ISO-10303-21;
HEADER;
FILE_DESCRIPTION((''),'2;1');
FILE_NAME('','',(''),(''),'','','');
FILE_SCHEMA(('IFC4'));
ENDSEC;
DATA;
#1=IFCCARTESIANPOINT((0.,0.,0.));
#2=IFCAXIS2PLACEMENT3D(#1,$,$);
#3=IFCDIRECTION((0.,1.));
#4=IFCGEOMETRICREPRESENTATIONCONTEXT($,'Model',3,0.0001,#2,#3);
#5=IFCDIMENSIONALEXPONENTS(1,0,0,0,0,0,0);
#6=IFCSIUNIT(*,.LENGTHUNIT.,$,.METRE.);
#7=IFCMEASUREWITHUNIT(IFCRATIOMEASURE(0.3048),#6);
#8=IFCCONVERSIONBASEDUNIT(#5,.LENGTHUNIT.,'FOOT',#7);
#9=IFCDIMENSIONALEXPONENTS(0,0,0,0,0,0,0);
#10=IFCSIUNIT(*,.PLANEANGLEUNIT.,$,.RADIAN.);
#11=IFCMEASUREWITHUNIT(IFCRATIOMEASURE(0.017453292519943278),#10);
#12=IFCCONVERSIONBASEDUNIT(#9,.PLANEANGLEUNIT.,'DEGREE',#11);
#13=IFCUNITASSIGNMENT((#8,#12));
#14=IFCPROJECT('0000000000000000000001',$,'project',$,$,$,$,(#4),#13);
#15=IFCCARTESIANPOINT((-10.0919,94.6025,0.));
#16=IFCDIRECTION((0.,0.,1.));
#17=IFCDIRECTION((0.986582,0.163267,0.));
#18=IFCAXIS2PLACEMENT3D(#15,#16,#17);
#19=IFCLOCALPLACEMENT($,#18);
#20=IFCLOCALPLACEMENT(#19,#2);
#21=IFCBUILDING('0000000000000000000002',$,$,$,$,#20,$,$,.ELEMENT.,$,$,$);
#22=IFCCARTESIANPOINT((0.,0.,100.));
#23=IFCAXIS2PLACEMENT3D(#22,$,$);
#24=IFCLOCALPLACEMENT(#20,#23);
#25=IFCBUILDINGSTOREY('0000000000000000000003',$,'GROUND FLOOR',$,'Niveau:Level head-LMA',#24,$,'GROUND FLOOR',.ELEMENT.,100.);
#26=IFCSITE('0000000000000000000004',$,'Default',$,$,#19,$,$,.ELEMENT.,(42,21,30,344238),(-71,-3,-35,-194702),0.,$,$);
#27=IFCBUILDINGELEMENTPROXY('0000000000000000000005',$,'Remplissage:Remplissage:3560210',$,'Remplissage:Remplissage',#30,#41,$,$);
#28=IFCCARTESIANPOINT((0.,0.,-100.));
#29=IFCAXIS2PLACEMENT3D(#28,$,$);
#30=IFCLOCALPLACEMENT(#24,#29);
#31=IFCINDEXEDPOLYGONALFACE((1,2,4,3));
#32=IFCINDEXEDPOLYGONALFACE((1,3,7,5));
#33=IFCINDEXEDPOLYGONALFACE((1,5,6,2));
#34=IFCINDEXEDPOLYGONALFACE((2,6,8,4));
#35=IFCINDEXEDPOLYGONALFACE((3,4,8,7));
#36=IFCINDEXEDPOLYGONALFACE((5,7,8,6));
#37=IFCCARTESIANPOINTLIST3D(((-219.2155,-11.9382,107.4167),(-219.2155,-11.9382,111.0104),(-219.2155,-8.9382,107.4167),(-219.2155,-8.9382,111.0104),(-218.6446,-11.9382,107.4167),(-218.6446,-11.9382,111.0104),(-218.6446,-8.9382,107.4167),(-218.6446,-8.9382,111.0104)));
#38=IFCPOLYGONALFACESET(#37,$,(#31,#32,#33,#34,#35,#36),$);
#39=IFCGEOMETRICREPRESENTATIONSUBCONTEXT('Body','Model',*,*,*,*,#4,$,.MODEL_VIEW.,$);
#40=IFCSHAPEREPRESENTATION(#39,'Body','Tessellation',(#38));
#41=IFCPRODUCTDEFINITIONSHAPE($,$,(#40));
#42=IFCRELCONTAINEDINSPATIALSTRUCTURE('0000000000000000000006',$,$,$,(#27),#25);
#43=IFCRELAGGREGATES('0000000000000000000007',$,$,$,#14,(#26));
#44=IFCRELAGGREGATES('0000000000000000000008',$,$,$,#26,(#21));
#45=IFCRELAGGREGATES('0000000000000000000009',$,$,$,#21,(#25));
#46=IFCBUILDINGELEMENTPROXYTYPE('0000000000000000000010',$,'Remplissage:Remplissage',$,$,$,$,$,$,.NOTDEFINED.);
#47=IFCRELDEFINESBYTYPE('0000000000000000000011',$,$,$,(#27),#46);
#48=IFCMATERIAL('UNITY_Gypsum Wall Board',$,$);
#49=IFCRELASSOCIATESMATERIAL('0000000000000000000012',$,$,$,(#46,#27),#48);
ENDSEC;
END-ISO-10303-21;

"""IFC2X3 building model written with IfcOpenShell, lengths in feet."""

from ifc_helpers import new_model, entity, si_unit, converted_unit, direction, frame, origin, origin_2d_with_axis, place, context, subcontext, project, spatial, rectangle, extrude, source, transform, mapped, material, type_object, type_shapes, element, save


model = new_model("IFC2X3")

# Units and contexts
model_context = context("Model", 3, precision=0.0001, world=origin(), true_north=direction((0.0, 1.0)))
body_context = subcontext(model_context, "Body", "Model", "MODEL_VIEW")
ifc_project = project(units=[converted_unit("LENGTHUNIT", "FOOT", entity("IfcRatioMeasure", 0.3048), si_unit("LENGTHUNIT", "METRE"), dimensions=[1, 0, 0, 0, 0, 0, 0]), converted_unit("PLANEANGLEUNIT", "DEGREE", entity("IfcRatioMeasure", 0.017453292519943278), si_unit("PLANEANGLEUNIT", "RADIAN"), dimensions=[0, 0, 0, 0, 0, 0, 0])], contexts=[model_context])

# Site, building, storey
site_placement = place(None, frame((-10.0919, 94.6025, 0.0), z_axis=(0.0, 0.0, 1.0), x_axis=(0.986582, 0.163267, 0.0)))
site = spatial("IfcSite", under=ifc_project, at=site_placement, Name="Default", CompositionType="ELEMENT", RefLatitude=(42, 21, 30, 344238), RefLongitude=(-71, -3, -35, -194702), RefElevation=0.0)
building_placement = place(site_placement, origin())
building = spatial("IfcBuilding", under=site, at=building_placement, CompositionType="ELEMENT")
storey_placement = place(building_placement, frame((0.0, 0.0, 100.0)))
storey = spatial("IfcBuildingStorey", under=building, at=storey_placement, Name="GROUND FLOOR", ObjectType="Niveau:Level head-LMA", LongName="GROUND FLOOR", CompositionType="ELEMENT", Elevation=100.0)

# Building element proxy
ifc_material_1 = material(Name="UNITY_Gypsum Wall Board")
building_element_proxy_type_1 = type_object("IfcBuildingElementProxyType", Name="Remplissage:Remplissage", PredefinedType="NOTDEFINED", material=ifc_material_1)
shared_shape_1 = source(origin(), body_context, "Body", "SweptSolid", [
    extrude(rectangle(XDim=0.5709, YDim=3.0, at=origin_2d_with_axis()), frame((-218.9301, -10.4382, 107.4167), z_axis=(0.0, 0.0, 1.0), x_axis=(-1.0, 0.0, 0.0)), (0.0, 0.0, 1.0), 3.5937),
])
type_shapes(building_element_proxy_type_1, [shared_shape_1])
proxy_1_placement = place(storey_placement, frame((0.0, 0.0, -100.0)))
element("IfcBuildingElementProxy", 1, at=proxy_1_placement, inside=storey, type_object=building_element_proxy_type_1, material=ifc_material_1, Name="Remplissage:Remplissage:3560210", ObjectType="Remplissage:Remplissage", context=body_context, shape_type="MappedRepresentation", body=[
    mapped(shared_shape_1, transform((0.0, 0.0, 0.0), scale=1.0)),
])

save(model, "model.ifc")
